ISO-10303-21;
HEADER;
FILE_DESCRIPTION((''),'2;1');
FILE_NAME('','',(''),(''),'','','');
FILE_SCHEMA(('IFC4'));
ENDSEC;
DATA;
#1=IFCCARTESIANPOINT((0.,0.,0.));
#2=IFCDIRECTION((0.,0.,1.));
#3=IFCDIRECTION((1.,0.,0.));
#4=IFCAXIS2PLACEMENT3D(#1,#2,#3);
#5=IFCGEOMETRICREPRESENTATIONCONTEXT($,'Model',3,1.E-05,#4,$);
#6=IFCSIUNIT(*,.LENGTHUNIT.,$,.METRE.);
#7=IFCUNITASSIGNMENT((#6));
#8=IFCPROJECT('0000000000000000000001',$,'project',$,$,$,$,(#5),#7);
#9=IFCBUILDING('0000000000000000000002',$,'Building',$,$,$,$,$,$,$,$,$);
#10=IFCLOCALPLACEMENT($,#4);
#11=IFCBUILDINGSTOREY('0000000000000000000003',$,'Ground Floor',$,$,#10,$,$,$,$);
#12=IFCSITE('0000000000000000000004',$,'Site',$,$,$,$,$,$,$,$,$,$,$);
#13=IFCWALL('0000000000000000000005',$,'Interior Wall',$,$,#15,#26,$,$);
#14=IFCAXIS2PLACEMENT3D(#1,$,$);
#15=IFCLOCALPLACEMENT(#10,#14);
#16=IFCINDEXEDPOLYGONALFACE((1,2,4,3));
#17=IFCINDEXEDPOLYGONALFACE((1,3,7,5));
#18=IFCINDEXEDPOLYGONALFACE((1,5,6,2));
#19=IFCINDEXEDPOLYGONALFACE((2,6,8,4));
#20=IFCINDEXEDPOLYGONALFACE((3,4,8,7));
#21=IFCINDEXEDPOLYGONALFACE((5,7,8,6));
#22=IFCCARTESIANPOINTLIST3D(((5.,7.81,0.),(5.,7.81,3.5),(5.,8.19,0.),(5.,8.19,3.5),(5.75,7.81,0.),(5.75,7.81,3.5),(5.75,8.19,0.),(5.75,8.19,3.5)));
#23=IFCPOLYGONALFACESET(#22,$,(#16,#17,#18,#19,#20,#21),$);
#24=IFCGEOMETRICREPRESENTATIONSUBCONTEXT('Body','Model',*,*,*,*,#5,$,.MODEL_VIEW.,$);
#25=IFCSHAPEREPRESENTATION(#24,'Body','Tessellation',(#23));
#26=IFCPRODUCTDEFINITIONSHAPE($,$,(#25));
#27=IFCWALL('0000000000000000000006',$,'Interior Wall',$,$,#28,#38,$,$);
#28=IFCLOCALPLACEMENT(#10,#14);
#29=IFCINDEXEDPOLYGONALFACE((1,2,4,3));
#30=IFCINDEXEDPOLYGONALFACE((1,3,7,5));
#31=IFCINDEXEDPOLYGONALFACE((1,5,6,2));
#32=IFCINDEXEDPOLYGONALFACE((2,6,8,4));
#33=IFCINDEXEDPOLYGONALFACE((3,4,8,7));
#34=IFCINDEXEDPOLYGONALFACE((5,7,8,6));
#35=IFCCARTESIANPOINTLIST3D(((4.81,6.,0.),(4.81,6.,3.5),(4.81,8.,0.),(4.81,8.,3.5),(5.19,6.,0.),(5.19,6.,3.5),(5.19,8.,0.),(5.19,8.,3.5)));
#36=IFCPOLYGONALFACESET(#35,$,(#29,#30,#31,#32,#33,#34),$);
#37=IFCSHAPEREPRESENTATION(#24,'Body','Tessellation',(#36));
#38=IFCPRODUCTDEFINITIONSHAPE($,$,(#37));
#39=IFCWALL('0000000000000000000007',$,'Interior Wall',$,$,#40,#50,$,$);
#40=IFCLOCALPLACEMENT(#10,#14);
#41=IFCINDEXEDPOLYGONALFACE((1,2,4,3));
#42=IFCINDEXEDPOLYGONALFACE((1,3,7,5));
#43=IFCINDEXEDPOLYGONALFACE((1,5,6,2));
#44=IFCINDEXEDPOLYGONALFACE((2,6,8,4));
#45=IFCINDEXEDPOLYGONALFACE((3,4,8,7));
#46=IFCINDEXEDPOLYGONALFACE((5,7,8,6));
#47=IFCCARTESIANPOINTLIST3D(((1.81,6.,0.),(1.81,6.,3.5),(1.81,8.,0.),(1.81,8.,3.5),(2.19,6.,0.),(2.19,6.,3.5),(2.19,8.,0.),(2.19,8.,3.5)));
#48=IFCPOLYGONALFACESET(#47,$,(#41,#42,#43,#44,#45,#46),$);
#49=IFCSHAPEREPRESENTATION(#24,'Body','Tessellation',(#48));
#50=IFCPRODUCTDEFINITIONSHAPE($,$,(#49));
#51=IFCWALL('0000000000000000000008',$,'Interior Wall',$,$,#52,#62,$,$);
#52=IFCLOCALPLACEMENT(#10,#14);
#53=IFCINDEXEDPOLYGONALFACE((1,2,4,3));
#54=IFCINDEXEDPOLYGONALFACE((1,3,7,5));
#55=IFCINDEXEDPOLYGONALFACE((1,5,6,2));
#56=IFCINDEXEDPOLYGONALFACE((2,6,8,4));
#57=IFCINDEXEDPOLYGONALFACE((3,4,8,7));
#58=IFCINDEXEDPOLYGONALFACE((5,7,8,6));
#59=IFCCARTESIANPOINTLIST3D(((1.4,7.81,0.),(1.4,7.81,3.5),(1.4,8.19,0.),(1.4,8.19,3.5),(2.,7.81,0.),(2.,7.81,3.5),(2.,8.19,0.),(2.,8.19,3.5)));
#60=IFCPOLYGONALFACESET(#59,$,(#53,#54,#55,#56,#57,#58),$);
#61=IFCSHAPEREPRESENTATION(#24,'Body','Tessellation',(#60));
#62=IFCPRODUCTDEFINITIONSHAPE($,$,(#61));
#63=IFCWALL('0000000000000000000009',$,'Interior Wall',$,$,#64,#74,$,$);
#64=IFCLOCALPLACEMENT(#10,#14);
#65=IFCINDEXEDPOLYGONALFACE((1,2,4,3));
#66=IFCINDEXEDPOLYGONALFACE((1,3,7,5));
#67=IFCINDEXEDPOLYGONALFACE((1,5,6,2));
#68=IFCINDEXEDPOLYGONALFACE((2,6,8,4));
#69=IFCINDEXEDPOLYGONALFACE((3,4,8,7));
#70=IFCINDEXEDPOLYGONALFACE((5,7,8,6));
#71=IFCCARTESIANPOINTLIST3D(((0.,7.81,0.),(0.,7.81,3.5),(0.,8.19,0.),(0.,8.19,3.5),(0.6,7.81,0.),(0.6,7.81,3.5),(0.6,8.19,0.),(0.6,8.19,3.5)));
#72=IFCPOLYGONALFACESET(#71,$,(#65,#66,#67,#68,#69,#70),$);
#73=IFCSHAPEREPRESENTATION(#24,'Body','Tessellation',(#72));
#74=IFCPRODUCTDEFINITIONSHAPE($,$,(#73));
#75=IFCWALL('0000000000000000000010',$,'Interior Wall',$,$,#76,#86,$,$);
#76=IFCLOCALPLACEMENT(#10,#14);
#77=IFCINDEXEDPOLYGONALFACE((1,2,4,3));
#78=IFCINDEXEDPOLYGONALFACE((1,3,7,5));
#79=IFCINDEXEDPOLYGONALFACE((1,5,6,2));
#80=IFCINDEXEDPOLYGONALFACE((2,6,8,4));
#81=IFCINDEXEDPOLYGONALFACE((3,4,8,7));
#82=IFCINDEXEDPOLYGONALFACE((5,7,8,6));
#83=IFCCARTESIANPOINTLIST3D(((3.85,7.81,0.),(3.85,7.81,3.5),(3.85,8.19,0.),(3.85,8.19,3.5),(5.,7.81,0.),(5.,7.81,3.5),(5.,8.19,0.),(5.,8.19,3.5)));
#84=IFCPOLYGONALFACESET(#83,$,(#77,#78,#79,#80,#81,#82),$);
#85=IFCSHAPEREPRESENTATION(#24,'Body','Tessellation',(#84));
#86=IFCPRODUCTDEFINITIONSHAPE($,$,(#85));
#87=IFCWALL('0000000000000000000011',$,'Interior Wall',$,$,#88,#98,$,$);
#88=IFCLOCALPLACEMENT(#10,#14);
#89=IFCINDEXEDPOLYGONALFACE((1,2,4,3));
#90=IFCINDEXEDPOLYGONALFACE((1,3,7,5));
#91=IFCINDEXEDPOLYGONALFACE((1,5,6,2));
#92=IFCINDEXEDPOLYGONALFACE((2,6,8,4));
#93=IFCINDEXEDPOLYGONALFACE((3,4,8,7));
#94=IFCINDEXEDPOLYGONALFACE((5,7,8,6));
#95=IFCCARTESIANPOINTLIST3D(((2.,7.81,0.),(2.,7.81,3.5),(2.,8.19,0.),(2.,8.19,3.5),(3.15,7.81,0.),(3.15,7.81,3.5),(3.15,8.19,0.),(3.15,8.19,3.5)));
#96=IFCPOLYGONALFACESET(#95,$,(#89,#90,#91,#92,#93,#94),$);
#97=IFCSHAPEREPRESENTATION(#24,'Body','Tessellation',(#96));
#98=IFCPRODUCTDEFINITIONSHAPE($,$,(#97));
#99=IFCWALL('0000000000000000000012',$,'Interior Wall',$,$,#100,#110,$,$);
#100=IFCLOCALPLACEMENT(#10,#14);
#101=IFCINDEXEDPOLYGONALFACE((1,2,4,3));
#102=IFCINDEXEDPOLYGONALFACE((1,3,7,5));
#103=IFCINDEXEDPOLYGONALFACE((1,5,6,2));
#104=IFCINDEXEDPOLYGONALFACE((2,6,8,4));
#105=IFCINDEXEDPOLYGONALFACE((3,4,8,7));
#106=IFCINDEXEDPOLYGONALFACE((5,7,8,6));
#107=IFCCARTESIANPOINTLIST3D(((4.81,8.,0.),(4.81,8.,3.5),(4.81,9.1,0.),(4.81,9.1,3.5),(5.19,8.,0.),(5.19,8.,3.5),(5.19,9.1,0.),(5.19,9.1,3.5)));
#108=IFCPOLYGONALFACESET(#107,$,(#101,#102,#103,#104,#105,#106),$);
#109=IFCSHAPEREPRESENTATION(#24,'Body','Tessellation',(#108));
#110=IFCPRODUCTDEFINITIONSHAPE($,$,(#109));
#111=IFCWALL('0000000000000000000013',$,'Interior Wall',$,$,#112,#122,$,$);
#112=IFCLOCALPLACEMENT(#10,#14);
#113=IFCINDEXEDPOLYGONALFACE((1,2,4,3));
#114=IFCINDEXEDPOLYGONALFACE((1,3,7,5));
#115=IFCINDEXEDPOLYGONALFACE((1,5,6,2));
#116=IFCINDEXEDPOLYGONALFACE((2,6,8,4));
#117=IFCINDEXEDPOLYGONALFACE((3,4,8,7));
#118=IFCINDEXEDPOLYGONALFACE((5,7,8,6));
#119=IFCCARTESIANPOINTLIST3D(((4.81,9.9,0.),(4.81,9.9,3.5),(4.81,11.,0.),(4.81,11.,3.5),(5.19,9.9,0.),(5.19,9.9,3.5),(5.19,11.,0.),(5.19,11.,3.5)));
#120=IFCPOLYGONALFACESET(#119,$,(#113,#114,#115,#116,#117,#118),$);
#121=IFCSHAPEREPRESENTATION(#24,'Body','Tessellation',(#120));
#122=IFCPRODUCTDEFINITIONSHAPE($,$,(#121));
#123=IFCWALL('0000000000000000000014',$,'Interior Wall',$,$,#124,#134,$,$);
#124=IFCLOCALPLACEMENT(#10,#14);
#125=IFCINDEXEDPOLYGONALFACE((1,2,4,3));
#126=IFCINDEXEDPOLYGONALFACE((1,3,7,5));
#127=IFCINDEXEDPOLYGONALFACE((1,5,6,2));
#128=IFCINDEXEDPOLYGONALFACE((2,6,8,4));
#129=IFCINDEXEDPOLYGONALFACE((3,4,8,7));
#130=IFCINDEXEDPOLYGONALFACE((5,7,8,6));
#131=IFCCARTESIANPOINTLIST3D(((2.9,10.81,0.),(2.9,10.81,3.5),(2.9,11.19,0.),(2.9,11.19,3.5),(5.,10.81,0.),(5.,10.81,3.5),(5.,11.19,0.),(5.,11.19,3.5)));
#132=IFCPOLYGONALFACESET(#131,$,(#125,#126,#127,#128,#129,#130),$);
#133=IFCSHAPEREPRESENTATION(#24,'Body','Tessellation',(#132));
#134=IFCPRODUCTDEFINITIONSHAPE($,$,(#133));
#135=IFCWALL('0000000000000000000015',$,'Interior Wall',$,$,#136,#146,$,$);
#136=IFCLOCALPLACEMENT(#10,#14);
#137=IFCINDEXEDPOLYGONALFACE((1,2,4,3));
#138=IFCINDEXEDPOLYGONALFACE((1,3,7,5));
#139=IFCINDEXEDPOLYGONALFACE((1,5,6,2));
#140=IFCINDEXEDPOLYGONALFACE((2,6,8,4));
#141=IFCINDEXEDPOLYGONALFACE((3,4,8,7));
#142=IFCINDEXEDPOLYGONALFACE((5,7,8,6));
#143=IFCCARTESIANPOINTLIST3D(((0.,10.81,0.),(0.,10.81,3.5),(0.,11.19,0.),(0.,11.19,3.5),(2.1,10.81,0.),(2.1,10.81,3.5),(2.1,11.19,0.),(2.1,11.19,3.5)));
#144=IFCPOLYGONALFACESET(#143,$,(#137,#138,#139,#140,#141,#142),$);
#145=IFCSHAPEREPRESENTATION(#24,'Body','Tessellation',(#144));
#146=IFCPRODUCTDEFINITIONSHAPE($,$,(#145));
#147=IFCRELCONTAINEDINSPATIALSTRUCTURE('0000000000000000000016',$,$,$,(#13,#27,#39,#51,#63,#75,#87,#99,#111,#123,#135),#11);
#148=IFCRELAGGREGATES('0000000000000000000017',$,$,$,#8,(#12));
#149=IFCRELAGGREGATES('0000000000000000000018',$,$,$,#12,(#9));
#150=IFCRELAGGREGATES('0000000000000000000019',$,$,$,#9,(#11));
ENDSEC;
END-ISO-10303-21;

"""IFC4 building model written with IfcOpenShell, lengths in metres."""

from ifc_helpers import new_model, si_unit, frame, origin_with_axes, place, context, subcontext, project, spatial, indexed_curve, outline, extrude, element, save


model = new_model("IFC4")

# Units and contexts
model_context = context("Model", 3, precision=1e-05, world=origin_with_axes())
body_context = subcontext(model_context, "Body", "Model", "MODEL_VIEW")
ifc_project = project(units=[si_unit("LENGTHUNIT", "METRE")], contexts=[model_context])

# Site, building, storey
site = spatial("IfcSite", under=ifc_project, Name="Site")
building = spatial("IfcBuilding", under=site, Name="Building")
storey_placement = place(None, origin_with_axes())
storey = spatial("IfcBuildingStorey", under=building, at=storey_placement, Name="Ground Floor")

# Walls
wall_1_placement = place(storey_placement, frame((5.75, 8.0, 0.0), z_axis=(0.0, 0.0, 1.0), x_axis=(-1.0, 0.0, 0.0)))
element("IfcWall", 1, at=wall_1_placement, inside=storey, Name="Interior Wall", context=body_context, shape_type="SweptSolid", body=[
    extrude(outline(indexed_curve([(0.0, 0.0), (0.0, 0.38), (0.75, 0.38), (0.75, 0.0), (0.0, 0.0)], self_intersect=False)), frame((0.0, -0.19, 0.0), z_axis=(0.0, 0.0, 1.0), x_axis=(1.0, 0.0, 0.0)), (0.0, 0.0, 1.0), 3.5),
])
for number, where, z_axis, x_axis, name in (
    (2, (5.0, 8.0, 0.0), (0.0, 0.0, 1.0), (0.0, -1.0, 0.0), "Interior Wall"),
    (3, (2.0, 6.0, 0.0), (0.0, 0.0, 1.0), (0.0, 1.0, 0.0), "Interior Wall"),
):
    element("IfcWall", number, at=place(storey_placement, frame(where, z_axis=z_axis, x_axis=x_axis)), inside=storey, Name=name, context=body_context, shape_type="SweptSolid", body=[
        extrude(outline(indexed_curve([(0.0, 0.0), (0.0, 0.38), (2.0, 0.38), (2.0, 0.0), (0.0, 0.0)], self_intersect=False)), frame((0.0, -0.19, 0.0), z_axis=(0.0, 0.0, 1.0), x_axis=(1.0, 0.0, 0.0)), (0.0, 0.0, 1.0), 3.5),
    ])
for number, where, z_axis, x_axis, name in (
    (4, (2.0, 8.0, 0.0), (0.0, 0.0, 1.0), (-1.0, 0.0, 0.0), "Interior Wall"),
    (5, (0.6, 8.0, 0.0), (0.0, 0.0, 1.0), (-1.0, 0.0, 0.0), "Interior Wall"),
):
    element("IfcWall", number, at=place(storey_placement, frame(where, z_axis=z_axis, x_axis=x_axis)), inside=storey, Name=name, context=body_context, shape_type="SweptSolid", body=[
        extrude(outline(indexed_curve([(0.0, 0.0), (0.0, 0.38), (0.6, 0.38), (0.6, 0.0), (0.0, 0.0)], self_intersect=False)), frame((0.0, -0.19, 0.0), z_axis=(0.0, 0.0, 1.0), x_axis=(1.0, 0.0, 0.0)), (0.0, 0.0, 1.0), 3.5),
    ])
for number, where, z_axis, x_axis, name in (
    (6, (5.0, 8.0, 0.0), (0.0, 0.0, 1.0), (-1.0, 0.0, 0.0), "Interior Wall"),
    (7, (3.15, 8.0, 0.0), (0.0, 0.0, 1.0), (-1.0, 0.0, 0.0), "Interior Wall"),
):
    element("IfcWall", number, at=place(storey_placement, frame(where, z_axis=z_axis, x_axis=x_axis)), inside=storey, Name=name, context=body_context, shape_type="SweptSolid", body=[
        extrude(outline(indexed_curve([(0.0, 0.0), (0.0, 0.38), (1.15, 0.38), (1.15, 0.0), (0.0, 0.0)], self_intersect=False)), frame((0.0, -0.19, 0.0), z_axis=(0.0, 0.0, 1.0), x_axis=(1.0, 0.0, 0.0)), (0.0, 0.0, 1.0), 3.5),
    ])
for number, where, z_axis, x_axis, name in (
    (8, (5.0, 8.0, 0.0), (0.0, 0.0, 1.0), (0.0, 1.0, 0.0), "Interior Wall"),
    (9, (5.0, 9.9, 0.0), (0.0, 0.0, 1.0), (0.0, 1.0, 0.0), "Interior Wall"),
):
    element("IfcWall", number, at=place(storey_placement, frame(where, z_axis=z_axis, x_axis=x_axis)), inside=storey, Name=name, context=body_context, shape_type="SweptSolid", body=[
        extrude(outline(indexed_curve([(0.0, 0.0), (0.0, 0.38), (1.1, 0.38), (1.1, 0.0), (0.0, 0.0)], self_intersect=False)), frame((0.0, -0.19, 0.0), z_axis=(0.0, 0.0, 1.0), x_axis=(1.0, 0.0, 0.0)), (0.0, 0.0, 1.0), 3.5),
    ])
for number, where, z_axis, x_axis, name in (
    (10, (5.0, 11.0, 0.0), (0.0, 0.0, 1.0), (-1.0, 0.0, 0.0), "Interior Wall"),
    (11, (2.1, 11.0, 0.0), (0.0, 0.0, 1.0), (-1.0, 0.0, 0.0), "Interior Wall"),
):
    element("IfcWall", number, at=place(storey_placement, frame(where, z_axis=z_axis, x_axis=x_axis)), inside=storey, Name=name, context=body_context, shape_type="SweptSolid", body=[
        extrude(outline(indexed_curve([(0.0, 0.0), (0.0, 0.38), (2.1, 0.38), (2.1, 0.0), (0.0, 0.0)], self_intersect=False)), frame((0.0, -0.19, 0.0), z_axis=(0.0, 0.0, 1.0), x_axis=(1.0, 0.0, 0.0)), (0.0, 0.0, 1.0), 3.5),
    ])

save(model, "model.ifc")
